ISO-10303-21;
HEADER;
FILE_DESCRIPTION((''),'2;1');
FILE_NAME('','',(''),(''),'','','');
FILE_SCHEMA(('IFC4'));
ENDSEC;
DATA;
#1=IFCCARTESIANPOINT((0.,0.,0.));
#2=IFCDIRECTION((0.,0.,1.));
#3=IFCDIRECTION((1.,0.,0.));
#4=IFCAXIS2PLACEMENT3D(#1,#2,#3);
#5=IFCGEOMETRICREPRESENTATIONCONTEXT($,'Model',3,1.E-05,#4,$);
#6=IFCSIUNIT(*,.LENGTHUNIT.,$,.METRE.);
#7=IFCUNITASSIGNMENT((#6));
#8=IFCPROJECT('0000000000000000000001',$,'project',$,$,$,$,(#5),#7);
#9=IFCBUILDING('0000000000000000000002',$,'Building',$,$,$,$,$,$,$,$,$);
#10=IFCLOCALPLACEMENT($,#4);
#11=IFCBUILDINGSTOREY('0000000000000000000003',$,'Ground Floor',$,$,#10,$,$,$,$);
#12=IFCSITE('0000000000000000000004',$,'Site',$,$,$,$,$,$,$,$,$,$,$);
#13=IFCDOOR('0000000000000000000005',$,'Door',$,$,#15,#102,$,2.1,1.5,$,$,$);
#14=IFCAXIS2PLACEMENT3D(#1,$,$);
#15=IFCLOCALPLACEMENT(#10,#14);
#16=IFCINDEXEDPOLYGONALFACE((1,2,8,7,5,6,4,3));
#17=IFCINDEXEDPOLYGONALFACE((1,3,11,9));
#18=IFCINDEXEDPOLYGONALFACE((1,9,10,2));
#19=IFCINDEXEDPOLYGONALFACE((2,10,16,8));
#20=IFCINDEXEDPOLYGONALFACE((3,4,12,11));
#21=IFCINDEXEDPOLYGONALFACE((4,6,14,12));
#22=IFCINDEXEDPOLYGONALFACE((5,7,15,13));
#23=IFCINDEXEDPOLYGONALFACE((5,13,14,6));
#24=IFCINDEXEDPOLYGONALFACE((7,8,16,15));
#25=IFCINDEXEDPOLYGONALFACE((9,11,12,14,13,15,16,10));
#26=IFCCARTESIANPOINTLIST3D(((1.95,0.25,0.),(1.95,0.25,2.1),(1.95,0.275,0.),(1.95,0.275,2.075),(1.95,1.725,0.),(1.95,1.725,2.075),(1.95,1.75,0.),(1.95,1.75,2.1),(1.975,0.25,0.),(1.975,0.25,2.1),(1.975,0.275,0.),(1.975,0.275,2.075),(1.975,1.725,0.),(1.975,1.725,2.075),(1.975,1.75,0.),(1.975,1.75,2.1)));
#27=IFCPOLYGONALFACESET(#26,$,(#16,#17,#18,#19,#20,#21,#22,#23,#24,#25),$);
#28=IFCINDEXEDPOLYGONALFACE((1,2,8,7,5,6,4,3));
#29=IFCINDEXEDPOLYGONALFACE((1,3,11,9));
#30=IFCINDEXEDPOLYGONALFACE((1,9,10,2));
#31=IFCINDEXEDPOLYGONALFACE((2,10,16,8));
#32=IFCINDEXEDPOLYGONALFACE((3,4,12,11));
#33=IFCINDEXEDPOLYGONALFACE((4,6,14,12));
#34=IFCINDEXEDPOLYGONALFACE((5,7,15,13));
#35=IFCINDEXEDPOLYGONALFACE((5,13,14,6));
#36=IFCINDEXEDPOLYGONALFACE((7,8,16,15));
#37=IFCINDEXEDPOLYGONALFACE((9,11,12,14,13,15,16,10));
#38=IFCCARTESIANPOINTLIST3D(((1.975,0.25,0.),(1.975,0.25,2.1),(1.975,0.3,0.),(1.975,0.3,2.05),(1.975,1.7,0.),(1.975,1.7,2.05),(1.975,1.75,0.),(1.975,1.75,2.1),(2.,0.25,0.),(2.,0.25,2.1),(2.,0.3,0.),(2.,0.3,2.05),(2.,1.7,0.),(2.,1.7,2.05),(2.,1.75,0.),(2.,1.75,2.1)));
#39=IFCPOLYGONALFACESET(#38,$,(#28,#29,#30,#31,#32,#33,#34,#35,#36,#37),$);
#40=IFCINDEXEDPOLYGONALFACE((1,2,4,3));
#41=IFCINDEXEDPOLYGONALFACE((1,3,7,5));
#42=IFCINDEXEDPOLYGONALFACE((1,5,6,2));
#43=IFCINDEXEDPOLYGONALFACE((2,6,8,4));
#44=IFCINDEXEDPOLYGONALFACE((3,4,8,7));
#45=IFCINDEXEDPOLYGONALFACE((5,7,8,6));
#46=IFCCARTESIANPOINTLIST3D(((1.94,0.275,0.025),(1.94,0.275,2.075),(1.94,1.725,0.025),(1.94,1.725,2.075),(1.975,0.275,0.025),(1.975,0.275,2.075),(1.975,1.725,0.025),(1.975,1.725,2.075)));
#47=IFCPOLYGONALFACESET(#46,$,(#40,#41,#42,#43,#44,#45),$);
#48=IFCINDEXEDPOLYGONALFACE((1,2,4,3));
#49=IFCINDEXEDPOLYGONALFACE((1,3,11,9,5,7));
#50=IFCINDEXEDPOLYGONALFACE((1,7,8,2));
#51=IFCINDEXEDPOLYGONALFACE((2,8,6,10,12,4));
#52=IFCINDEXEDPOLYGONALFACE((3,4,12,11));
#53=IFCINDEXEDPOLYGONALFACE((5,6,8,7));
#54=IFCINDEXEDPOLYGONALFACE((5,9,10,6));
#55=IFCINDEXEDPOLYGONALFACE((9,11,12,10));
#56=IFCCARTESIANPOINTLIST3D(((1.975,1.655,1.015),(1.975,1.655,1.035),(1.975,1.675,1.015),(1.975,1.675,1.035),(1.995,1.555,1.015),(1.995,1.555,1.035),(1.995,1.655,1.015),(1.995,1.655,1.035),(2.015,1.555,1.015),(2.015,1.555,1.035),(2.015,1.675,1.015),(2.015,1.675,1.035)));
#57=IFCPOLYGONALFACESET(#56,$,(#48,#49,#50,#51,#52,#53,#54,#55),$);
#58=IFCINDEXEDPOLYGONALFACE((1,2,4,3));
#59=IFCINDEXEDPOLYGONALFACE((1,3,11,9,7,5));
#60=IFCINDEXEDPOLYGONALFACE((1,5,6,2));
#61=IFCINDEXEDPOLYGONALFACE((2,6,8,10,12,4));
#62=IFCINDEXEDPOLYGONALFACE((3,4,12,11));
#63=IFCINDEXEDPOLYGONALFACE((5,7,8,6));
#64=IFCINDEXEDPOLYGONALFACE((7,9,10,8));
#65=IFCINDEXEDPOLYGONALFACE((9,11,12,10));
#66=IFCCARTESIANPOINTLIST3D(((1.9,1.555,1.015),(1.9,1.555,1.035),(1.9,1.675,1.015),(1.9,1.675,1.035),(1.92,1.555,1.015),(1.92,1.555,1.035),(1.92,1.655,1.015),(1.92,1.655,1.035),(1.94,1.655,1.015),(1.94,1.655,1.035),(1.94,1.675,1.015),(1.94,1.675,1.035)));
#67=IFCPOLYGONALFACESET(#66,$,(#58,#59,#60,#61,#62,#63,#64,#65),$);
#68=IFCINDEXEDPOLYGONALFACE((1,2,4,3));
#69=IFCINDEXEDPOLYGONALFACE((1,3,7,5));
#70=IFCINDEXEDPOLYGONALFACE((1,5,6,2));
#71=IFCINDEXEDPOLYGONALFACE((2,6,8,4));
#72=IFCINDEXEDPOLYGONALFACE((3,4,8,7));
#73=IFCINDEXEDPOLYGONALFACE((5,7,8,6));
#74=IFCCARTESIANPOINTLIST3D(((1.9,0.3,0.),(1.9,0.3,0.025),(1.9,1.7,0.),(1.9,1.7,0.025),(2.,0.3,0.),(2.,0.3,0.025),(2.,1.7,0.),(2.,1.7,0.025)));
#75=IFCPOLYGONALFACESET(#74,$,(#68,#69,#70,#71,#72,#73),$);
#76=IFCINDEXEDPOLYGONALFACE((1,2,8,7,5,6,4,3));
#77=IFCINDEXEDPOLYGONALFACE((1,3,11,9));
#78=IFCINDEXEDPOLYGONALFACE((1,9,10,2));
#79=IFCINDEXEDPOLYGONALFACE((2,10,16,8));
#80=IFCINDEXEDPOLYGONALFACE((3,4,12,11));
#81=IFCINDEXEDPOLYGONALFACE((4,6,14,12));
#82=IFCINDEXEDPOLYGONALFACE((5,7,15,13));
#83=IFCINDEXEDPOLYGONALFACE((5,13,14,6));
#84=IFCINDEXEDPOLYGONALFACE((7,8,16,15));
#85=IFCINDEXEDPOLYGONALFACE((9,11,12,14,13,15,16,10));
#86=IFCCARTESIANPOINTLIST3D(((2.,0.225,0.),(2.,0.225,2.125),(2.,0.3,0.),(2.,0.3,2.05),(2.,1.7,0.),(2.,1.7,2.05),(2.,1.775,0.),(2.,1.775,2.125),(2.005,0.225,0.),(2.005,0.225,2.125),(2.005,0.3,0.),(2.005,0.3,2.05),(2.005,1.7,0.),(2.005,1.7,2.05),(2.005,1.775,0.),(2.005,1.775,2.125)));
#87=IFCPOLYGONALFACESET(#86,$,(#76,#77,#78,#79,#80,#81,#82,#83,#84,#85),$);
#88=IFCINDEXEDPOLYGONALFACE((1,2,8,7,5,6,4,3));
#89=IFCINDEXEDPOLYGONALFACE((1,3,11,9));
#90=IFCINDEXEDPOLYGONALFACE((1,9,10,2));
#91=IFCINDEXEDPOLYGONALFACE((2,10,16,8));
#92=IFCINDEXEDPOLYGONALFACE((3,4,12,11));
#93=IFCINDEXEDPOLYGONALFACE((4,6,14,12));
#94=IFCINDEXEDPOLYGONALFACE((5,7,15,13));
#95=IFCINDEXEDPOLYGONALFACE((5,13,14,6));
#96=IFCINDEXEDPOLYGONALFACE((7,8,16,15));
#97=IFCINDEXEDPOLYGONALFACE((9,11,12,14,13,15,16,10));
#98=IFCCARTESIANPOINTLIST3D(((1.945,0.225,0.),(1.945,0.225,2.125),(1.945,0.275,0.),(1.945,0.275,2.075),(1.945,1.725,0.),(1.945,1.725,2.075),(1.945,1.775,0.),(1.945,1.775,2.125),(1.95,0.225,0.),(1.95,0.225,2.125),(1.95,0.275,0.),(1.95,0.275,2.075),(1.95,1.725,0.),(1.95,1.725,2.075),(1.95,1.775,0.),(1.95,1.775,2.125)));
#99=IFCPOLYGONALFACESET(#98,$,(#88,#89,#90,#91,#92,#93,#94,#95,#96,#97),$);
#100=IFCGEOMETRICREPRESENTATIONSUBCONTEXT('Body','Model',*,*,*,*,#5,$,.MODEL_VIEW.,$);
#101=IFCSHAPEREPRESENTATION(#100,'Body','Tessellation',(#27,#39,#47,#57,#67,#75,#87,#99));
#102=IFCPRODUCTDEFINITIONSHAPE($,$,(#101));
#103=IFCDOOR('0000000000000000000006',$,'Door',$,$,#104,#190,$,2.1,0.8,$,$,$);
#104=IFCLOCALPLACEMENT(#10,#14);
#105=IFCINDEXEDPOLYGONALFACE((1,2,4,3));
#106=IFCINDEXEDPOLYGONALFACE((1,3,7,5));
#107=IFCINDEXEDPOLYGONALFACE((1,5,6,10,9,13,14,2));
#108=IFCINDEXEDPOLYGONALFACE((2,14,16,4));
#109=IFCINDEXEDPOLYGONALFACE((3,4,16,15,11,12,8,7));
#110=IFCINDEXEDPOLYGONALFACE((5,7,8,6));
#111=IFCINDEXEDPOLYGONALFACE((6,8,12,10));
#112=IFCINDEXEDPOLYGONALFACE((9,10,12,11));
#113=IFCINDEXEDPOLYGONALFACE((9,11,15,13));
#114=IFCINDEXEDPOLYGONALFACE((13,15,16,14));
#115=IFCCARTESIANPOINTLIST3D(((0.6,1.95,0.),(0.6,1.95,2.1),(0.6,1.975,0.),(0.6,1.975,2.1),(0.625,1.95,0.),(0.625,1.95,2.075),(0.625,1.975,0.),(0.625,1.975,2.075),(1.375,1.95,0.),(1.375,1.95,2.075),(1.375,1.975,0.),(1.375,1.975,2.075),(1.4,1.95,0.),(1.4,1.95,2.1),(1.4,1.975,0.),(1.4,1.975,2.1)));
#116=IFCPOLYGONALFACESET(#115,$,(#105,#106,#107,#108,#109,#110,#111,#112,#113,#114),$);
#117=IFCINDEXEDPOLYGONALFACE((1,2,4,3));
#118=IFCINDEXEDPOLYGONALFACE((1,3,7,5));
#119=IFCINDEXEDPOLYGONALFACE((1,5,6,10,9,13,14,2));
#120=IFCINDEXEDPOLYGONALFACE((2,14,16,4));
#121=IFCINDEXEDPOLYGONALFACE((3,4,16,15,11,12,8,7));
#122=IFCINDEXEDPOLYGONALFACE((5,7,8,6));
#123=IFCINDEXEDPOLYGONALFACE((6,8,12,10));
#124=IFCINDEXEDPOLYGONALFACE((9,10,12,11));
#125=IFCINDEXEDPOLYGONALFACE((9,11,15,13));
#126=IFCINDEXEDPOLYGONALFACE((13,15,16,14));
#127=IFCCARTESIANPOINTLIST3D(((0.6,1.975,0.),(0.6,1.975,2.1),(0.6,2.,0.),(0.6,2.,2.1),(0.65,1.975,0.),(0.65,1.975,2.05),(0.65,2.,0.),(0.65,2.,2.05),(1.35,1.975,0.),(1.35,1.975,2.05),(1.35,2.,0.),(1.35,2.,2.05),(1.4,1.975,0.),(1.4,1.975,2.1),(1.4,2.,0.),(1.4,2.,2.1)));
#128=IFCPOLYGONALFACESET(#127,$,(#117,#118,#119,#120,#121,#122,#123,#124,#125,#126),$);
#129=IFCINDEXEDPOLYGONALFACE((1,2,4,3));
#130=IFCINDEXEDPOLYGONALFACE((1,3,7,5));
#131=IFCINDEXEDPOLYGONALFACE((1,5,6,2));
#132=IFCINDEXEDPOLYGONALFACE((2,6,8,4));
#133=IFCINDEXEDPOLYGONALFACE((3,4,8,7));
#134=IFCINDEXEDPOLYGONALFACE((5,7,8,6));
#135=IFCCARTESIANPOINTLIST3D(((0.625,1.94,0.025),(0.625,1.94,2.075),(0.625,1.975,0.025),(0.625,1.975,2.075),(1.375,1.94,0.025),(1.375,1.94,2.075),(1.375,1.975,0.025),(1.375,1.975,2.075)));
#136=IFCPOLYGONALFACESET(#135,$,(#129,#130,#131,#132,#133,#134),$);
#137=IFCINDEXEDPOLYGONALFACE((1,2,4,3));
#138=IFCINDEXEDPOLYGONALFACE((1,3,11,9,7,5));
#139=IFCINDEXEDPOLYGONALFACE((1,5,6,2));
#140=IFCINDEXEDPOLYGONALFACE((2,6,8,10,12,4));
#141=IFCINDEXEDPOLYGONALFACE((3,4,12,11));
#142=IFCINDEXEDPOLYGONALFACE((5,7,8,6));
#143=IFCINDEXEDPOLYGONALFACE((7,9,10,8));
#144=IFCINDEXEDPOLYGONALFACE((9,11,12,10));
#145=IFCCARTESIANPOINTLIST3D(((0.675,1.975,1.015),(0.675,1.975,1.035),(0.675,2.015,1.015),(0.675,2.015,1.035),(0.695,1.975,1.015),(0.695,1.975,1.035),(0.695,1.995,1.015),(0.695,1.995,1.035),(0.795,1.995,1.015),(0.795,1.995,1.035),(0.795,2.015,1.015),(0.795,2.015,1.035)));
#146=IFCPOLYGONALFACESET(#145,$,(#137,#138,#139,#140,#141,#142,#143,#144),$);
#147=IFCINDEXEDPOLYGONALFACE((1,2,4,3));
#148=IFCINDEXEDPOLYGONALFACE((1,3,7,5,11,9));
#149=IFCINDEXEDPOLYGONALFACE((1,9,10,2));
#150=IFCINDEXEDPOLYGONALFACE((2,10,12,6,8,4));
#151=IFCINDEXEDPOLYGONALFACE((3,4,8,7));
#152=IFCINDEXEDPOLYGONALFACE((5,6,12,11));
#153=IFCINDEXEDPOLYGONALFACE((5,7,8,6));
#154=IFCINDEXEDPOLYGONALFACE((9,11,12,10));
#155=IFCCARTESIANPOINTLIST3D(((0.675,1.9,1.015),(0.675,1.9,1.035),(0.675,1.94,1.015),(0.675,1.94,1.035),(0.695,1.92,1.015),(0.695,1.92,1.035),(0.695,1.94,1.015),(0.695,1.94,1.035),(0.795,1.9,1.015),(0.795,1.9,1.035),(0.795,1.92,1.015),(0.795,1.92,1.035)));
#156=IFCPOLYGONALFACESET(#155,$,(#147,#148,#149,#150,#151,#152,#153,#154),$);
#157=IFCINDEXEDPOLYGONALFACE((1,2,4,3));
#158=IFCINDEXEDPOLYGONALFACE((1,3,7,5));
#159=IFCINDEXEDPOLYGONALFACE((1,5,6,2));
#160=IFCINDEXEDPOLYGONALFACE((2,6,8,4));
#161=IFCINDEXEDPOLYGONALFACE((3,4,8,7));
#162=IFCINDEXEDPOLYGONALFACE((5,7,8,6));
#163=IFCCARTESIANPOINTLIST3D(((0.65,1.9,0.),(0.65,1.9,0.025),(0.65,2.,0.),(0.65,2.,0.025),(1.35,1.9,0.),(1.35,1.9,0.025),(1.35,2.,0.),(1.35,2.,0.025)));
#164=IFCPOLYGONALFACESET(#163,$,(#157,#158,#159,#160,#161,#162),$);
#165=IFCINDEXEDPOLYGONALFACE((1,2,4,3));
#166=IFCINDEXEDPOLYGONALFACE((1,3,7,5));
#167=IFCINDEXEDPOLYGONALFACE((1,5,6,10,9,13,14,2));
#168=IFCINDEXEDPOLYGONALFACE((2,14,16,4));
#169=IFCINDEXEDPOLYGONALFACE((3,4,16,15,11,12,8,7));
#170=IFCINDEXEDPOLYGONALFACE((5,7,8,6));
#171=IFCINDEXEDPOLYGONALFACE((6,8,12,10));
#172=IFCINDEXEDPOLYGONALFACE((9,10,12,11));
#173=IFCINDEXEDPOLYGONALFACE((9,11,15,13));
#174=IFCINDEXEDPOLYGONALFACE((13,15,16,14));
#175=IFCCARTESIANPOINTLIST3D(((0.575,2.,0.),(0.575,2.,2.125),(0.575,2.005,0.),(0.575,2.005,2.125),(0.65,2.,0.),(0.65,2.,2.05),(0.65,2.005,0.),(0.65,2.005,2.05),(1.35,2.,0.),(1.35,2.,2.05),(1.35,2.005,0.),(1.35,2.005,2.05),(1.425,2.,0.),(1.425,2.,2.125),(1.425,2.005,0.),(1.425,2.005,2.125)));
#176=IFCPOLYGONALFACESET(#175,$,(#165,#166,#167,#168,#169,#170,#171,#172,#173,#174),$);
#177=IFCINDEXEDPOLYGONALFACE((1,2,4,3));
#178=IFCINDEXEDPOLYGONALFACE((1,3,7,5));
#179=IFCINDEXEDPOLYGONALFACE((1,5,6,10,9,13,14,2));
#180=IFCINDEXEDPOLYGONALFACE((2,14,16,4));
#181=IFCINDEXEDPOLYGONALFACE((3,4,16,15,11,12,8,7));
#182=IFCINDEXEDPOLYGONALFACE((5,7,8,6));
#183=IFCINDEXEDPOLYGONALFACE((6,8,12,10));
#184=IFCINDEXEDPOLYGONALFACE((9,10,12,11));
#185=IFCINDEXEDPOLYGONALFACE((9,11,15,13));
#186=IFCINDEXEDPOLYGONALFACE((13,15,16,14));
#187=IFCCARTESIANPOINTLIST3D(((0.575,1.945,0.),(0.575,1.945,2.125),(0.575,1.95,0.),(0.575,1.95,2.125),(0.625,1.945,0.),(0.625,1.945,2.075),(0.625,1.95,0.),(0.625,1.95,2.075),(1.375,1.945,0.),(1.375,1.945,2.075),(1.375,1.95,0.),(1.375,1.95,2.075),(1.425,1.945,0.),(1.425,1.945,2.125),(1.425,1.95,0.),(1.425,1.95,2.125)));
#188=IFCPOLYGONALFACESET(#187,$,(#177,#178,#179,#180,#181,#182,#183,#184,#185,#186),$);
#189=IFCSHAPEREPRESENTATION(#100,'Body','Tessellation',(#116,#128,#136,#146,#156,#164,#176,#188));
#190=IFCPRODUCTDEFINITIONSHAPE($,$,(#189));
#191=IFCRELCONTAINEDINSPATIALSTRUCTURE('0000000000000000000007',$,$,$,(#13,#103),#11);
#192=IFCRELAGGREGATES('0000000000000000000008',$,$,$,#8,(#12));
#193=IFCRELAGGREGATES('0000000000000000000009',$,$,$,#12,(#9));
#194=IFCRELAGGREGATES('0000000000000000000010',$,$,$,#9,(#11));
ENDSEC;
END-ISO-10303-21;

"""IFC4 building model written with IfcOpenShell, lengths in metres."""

from ifc_helpers import new_model, si_unit, frame, origin_with_axes, place, context, subcontext, project, spatial, line, indexed_curve, outline, extrude, element, save


model = new_model("IFC4")

# Units and contexts
model_context = context("Model", 3, precision=1e-05, world=origin_with_axes())
body_context = subcontext(model_context, "Body", "Model", "MODEL_VIEW")
ifc_project = project(units=[si_unit("LENGTHUNIT", "METRE")], contexts=[model_context])

# Site, building, storey
site = spatial("IfcSite", under=ifc_project, Name="Site")
building = spatial("IfcBuilding", under=site, Name="Building")
storey_placement = place(None, origin_with_axes())
storey = spatial("IfcBuildingStorey", under=building, at=storey_placement, Name="Ground Floor")

# Doors
door_1_placement = place(storey_placement, frame((2.0, 0.25, 0.0), z_axis=(0.0, 0.0, 1.0), x_axis=(0.0, 1.0, 0.0)))
element("IfcDoor", 1, at=door_1_placement, inside=storey, Name="Door", OverallHeight=2.1, OverallWidth=1.5, context=body_context, shape_type="SweptSolid", body=[
    extrude(outline(indexed_curve([(0.0, 0.0), (0.0, 2.1), (1.5, 2.1), (1.5, 0.0), (1.475, 0.0), (1.475, 2.075), (0.025, 2.075), (0.025, 0.0)], segments=[line(1, 2, 3, 4, 5, 6, 7, 8, 1)])), frame((0.0, 0.025, 0.0), z_axis=(0.0, -1.0, 0.0), x_axis=(1.0, 0.0, 0.0)), (0.0, 0.0, -1.0), 0.025),
    extrude(outline(indexed_curve([(0.0, 0.0), (0.0, 2.1), (1.5, 2.1), (1.5, 0.0), (1.45, 0.0), (1.45, 2.05), (0.05, 2.05), (0.05, 0.0)], segments=[line(1, 2, 3, 4, 5, 6, 7, 8, 1)])), frame((0.0, 0.0, 0.0), z_axis=(0.0, -1.0, 0.0), x_axis=(1.0, 0.0, 0.0)), (0.0, 0.0, -1.0), 0.025),
    extrude(outline(indexed_curve([(0.0, 0.0), (1.45, 0.0), (1.45, 0.035), (0.0, 0.035)], segments=[line(1, 2, 3, 4, 1)])), frame((0.025, 0.025, 0.025), z_axis=(0.0, 0.0, 1.0), x_axis=(1.0, 0.0, 0.0)), (0.0, 0.0, 1.0), 2.05),
    extrude(outline(indexed_curve([(0.0, 0.0), (0.0, -0.04), (-0.12, -0.04), (-0.12, -0.02), (-0.02, -0.02), (-0.02, 0.0)], segments=[line(1, 2, 3, 4, 5, 6, 1)])), frame((1.425, 0.025, 1.015), z_axis=(0.0, 0.0, 1.0), x_axis=(1.0, 0.0, 0.0)), (0.0, 0.0, 1.0), 0.02),
    extrude(outline(indexed_curve([(0.0, 0.0), (0.0, 0.04), (-0.12, 0.04), (-0.12, 0.02), (-0.02, 0.02), (-0.02, 0.0)], segments=[line(1, 2, 3, 4, 5, 6, 1)])), frame((1.425, 0.06, 1.015), z_axis=(0.0, 0.0, 1.0), x_axis=(1.0, 0.0, 0.0)), (0.0, 0.0, 1.0), 0.02),
    extrude(outline(indexed_curve([(0.0, 0.0), (1.4, 0.0), (1.4, 0.1), (0.0, 0.1)], segments=[line(1, 2, 3, 4, 1)])), frame((0.05, 0.0, 0.0), z_axis=(0.0, 0.0, 1.0), x_axis=(1.0, 0.0, 0.0)), (0.0, 0.0, 1.0), 0.025),
    extrude(outline(indexed_curve([(0.0, 0.0), (0.0, 2.125), (1.55, 2.125), (1.55, 0.0), (1.475, 0.0), (1.475, 2.05), (0.075, 2.05), (0.075, 0.0)], segments=[line(1, 2, 3, 4, 5, 6, 7, 8, 1)])), frame((-0.025, -0.005, 0.0), z_axis=(0.0, -1.0, 0.0), x_axis=(1.0, 0.0, 0.0)), (0.0, 0.0, -1.0), 0.005),
    extrude(outline(indexed_curve([(0.0, 0.0), (0.0, 2.125), (1.55, 2.125), (1.55, 0.0), (1.5, 0.0), (1.5, 2.075), (0.05, 2.075), (0.05, 0.0)], segments=[line(1, 2, 3, 4, 5, 6, 7, 8, 1)])), frame((-0.025, 0.05, 0.0), z_axis=(0.0, -1.0, 0.0), x_axis=(1.0, 0.0, 0.0)), (0.0, 0.0, -1.0), 0.005),
])
door_2_placement = place(storey_placement, frame((1.4, 2.0, 0.0), z_axis=(0.0, 0.0, 1.0), x_axis=(-1.0, 0.0, 0.0)))
element("IfcDoor", 2, at=door_2_placement, inside=storey, Name="Door", OverallHeight=2.1, OverallWidth=0.8, context=body_context, shape_type="SweptSolid", body=[
    extrude(outline(indexed_curve([(0.0, 0.0), (0.0, 2.1), (0.8, 2.1), (0.8, 0.0), (0.775, 0.0), (0.775, 2.075), (0.025, 2.075), (0.025, 0.0)], segments=[line(1, 2, 3, 4, 5, 6, 7, 8, 1)])), frame((0.0, 0.025, 0.0), z_axis=(0.0, -1.0, 0.0), x_axis=(1.0, 0.0, 0.0)), (0.0, 0.0, -1.0), 0.025),
    extrude(outline(indexed_curve([(0.0, 0.0), (0.0, 2.1), (0.8, 2.1), (0.8, 0.0), (0.75, 0.0), (0.75, 2.05), (0.05, 2.05), (0.05, 0.0)], segments=[line(1, 2, 3, 4, 5, 6, 7, 8, 1)])), frame((0.0, 0.0, 0.0), z_axis=(0.0, -1.0, 0.0), x_axis=(1.0, 0.0, 0.0)), (0.0, 0.0, -1.0), 0.025),
    extrude(outline(indexed_curve([(0.0, 0.0), (0.75, 0.0), (0.75, 0.035), (0.0, 0.035)], segments=[line(1, 2, 3, 4, 1)])), frame((0.025, 0.025, 0.025), z_axis=(0.0, 0.0, 1.0), x_axis=(1.0, 0.0, 0.0)), (0.0, 0.0, 1.0), 2.05),
    extrude(outline(indexed_curve([(0.0, 0.0), (0.0, -0.04), (-0.12, -0.04), (-0.12, -0.02), (-0.02, -0.02), (-0.02, 0.0)], segments=[line(1, 2, 3, 4, 5, 6, 1)])), frame((0.725, 0.025, 1.015), z_axis=(0.0, 0.0, 1.0), x_axis=(1.0, 0.0, 0.0)), (0.0, 0.0, 1.0), 0.02),
    extrude(outline(indexed_curve([(0.0, 0.0), (0.0, 0.04), (-0.12, 0.04), (-0.12, 0.02), (-0.02, 0.02), (-0.02, 0.0)], segments=[line(1, 2, 3, 4, 5, 6, 1)])), frame((0.725, 0.06, 1.015), z_axis=(0.0, 0.0, 1.0), x_axis=(1.0, 0.0, 0.0)), (0.0, 0.0, 1.0), 0.02),
    extrude(outline(indexed_curve([(0.0, 0.0), (0.7, 0.0), (0.7, 0.1), (0.0, 0.1)], segments=[line(1, 2, 3, 4, 1)])), frame((0.05, 0.0, 0.0), z_axis=(0.0, 0.0, 1.0), x_axis=(1.0, 0.0, 0.0)), (0.0, 0.0, 1.0), 0.025),
    extrude(outline(indexed_curve([(0.0, 0.0), (0.0, 2.125), (0.85, 2.125), (0.85, 0.0), (0.775, 0.0), (0.775, 2.05), (0.075, 2.05), (0.075, 0.0)], segments=[line(1, 2, 3, 4, 5, 6, 7, 8, 1)])), frame((-0.025, -0.005, 0.0), z_axis=(0.0, -1.0, 0.0), x_axis=(1.0, 0.0, 0.0)), (0.0, 0.0, -1.0), 0.005),
    extrude(outline(indexed_curve([(0.0, 0.0), (0.0, 2.125), (0.85, 2.125), (0.85, 0.0), (0.8, 0.0), (0.8, 2.075), (0.05, 2.075), (0.05, 0.0)], segments=[line(1, 2, 3, 4, 5, 6, 7, 8, 1)])), frame((-0.025, 0.05, 0.0), z_axis=(0.0, -1.0, 0.0), x_axis=(1.0, 0.0, 0.0)), (0.0, 0.0, -1.0), 0.005),
])

save(model, "model.ifc")
